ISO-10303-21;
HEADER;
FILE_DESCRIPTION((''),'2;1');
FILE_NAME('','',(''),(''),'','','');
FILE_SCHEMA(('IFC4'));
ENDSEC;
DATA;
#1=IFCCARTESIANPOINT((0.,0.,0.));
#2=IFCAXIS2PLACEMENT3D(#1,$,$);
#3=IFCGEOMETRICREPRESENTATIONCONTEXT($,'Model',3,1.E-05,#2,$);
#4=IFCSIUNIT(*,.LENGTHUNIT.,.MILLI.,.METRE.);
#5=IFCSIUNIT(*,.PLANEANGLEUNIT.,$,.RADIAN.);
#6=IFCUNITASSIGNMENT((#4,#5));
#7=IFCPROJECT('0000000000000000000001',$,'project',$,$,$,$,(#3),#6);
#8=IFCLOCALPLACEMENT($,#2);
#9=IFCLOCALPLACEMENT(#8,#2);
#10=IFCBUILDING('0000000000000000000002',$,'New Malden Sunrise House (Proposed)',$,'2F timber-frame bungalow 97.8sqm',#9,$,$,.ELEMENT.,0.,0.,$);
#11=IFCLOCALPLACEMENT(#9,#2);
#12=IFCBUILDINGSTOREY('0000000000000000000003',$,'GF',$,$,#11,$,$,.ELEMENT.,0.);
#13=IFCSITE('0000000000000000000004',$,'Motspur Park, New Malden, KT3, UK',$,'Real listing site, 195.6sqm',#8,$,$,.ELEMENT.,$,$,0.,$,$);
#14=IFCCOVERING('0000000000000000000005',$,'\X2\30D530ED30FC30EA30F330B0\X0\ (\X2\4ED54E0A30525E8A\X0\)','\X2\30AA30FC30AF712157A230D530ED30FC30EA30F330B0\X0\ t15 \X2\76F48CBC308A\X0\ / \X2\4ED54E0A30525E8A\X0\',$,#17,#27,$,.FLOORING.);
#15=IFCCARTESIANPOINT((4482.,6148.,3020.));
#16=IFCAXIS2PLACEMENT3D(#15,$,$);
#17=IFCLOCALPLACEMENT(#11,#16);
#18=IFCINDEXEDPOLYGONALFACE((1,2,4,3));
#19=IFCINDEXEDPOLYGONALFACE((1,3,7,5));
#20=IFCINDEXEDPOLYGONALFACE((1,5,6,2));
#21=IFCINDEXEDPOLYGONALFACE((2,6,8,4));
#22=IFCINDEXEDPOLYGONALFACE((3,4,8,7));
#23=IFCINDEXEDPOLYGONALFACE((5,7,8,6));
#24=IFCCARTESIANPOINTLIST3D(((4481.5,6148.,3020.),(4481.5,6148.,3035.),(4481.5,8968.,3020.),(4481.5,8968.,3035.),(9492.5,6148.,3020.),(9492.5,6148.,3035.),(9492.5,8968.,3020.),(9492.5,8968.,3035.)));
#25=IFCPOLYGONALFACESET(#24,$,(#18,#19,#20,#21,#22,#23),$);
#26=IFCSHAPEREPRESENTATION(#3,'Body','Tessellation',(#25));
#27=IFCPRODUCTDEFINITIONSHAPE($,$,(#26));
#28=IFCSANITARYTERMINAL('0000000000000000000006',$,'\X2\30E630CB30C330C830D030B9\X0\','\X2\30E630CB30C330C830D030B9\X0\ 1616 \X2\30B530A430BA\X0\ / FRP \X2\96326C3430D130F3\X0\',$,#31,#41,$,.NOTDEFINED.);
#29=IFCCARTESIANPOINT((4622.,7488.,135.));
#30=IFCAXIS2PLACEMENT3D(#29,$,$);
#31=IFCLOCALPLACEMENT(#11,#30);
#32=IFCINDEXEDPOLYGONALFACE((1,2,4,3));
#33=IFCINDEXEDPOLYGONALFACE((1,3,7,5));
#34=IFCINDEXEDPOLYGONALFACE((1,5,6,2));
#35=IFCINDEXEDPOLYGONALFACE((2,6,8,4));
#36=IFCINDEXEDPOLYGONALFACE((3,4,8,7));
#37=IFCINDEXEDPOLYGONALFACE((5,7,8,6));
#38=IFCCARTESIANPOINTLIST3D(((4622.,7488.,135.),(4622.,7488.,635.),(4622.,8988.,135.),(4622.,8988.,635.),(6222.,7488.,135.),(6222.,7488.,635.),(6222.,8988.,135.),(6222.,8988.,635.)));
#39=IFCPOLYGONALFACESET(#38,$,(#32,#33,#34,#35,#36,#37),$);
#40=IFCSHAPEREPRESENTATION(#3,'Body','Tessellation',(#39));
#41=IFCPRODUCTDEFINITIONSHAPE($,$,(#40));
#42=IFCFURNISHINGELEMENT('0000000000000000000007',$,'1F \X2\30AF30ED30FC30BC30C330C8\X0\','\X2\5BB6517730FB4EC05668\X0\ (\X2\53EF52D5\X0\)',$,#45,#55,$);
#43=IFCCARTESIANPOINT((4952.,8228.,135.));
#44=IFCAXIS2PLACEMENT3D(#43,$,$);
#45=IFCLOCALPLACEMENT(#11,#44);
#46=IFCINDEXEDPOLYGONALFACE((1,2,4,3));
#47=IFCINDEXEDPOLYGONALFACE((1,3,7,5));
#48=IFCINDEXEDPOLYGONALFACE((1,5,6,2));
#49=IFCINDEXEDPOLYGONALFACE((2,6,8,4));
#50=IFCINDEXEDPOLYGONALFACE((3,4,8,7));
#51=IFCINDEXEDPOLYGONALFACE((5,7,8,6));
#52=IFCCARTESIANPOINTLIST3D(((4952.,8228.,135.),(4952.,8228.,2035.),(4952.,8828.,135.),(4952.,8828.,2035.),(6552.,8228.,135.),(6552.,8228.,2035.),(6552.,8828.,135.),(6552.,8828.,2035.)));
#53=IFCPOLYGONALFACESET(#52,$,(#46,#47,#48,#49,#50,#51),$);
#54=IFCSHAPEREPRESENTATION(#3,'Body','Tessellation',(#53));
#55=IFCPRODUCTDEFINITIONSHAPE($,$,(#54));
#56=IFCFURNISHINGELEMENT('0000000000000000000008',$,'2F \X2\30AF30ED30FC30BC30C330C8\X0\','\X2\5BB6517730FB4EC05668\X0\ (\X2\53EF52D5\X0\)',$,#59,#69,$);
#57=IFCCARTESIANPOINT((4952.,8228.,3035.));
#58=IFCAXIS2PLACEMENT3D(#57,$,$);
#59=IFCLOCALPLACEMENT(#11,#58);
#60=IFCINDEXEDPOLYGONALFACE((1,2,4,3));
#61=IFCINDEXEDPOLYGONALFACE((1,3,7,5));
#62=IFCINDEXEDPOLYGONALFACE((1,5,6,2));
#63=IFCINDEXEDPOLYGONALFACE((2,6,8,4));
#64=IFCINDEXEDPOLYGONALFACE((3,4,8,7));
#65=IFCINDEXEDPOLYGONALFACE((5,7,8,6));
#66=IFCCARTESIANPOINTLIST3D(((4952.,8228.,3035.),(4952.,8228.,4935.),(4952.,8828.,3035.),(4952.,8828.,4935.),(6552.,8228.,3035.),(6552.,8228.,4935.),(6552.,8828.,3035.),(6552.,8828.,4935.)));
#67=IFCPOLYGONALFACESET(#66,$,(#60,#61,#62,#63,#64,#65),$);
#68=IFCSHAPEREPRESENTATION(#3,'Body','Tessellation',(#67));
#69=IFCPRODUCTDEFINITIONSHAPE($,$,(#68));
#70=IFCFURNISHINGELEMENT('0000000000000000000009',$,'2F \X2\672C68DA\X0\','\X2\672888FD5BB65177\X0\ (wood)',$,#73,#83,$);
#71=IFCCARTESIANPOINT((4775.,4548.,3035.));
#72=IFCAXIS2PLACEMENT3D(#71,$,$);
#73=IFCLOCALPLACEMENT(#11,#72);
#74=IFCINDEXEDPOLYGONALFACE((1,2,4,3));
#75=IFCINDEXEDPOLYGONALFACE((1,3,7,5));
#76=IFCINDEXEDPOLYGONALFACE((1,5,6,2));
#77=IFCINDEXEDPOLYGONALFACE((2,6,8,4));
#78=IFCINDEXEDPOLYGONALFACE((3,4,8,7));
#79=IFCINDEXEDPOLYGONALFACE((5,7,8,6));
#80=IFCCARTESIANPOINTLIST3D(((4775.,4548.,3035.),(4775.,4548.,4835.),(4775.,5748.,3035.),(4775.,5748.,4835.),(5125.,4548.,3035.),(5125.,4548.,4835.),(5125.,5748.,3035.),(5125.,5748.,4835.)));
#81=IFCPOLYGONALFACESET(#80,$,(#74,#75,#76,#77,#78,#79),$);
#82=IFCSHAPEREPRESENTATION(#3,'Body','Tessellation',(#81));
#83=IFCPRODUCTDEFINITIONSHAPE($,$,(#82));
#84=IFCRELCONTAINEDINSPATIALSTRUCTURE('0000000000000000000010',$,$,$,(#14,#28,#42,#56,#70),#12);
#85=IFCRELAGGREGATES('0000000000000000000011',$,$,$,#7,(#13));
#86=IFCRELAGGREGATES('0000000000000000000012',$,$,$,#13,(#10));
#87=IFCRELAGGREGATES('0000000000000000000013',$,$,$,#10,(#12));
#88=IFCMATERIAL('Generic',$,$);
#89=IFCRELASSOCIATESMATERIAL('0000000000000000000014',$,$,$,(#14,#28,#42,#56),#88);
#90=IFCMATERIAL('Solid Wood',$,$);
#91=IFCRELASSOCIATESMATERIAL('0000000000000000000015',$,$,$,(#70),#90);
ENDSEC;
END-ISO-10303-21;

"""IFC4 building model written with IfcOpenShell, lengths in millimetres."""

from ifc_helpers import new_model, si_unit, frame, frame_2d, origin, place, context, project, spatial, rectangle, extrude, material, element, save


model = new_model("IFC4")

# Units and contexts
model_context = context("Model", 3, precision=1e-05, world=origin())
ifc_project = project(units=[si_unit("LENGTHUNIT", "METRE", prefix="MILLI"), si_unit("PLANEANGLEUNIT", "RADIAN")], contexts=[model_context])

# Site, building, storey
site_placement = place(None, origin())
site = spatial("IfcSite", under=ifc_project, at=site_placement, Name="Motspur Park, New Malden, KT3, UK", ObjectType="Real listing site, 195.6sqm", CompositionType="ELEMENT", RefElevation=0.0)
building_placement = place(site_placement, origin())
building = spatial("IfcBuilding", under=site, at=building_placement, Name="New Malden Sunrise House (Proposed)", ObjectType="2F timber-frame bungalow 97.8sqm", CompositionType="ELEMENT", ElevationOfRefHeight=0.0, ElevationOfTerrain=0.0)
storey_placement = place(building_placement, origin())
storey = spatial("IfcBuildingStorey", under=building, at=storey_placement, Name="GF", CompositionType="ELEMENT", Elevation=0.0)

# Shared definitions
ifc_material_1 = material(Name="Solid Wood")

# Covering
ifc_material_2 = material(Name="Generic")
covering_1_placement = place(storey_placement, frame((4482.0, 6148.0, 3020.0)))
element("IfcCovering", 1, at=covering_1_placement, inside=storey, material=ifc_material_2, Name="フローリング (仕上げ床)", Description="オーク無垢フローリング t15 直貼り / 仕上げ床", PredefinedType="FLOORING", context=model_context, shape_type="SweptSolid", body=[
    extrude(rectangle(XDim=5011.0, YDim=2820.0, at=frame_2d((2505.0, 1410.0))), frame((4482.0, 6148.0, 3020.0)), (0.0, 0.0, 1.0), 15.0),
])

# Sanitary terminal
sanitary_terminal_placement = place(storey_placement, frame((4622.0, 7488.0, 135.0)))
element("IfcSanitaryTerminal", 2, at=sanitary_terminal_placement, inside=storey, material=ifc_material_2, Name="ユニットバス", Description="ユニットバス 1616 サイズ / FRP 防水パン", PredefinedType="NOTDEFINED", context=model_context, shape_type="SweptSolid", body=[
    extrude(rectangle(XDim=1600.0, YDim=1500.0, at=frame_2d((800.0, 750.0))), frame((4622.0, 7488.0, 135.0)), (0.0, 0.0, 1.0), 500.0),
])

# Furnishing elements
furnishing_1_placement = place(storey_placement, frame((4952.0, 8228.0, 135.0)))
element("IfcFurnishingElement", 3, at=furnishing_1_placement, inside=storey, material=ifc_material_2, Name="1F クローゼット", Description="家具・什器 (可動)", context=model_context, shape_type="SweptSolid", body=[
    extrude(rectangle(XDim=1600.0, YDim=600.0, at=frame_2d((800.0, 300.0))), frame((4952.0, 8228.0, 135.0)), (0.0, 0.0, 1.0), 1900.0),
])
furnishing_2_placement = place(storey_placement, frame((4952.0, 8228.0, 3035.0)))
element("IfcFurnishingElement", 4, at=furnishing_2_placement, inside=storey, material=ifc_material_2, Name="2F クローゼット", Description="家具・什器 (可動)", context=model_context, shape_type="SweptSolid", body=[
    extrude(rectangle(XDim=1600.0, YDim=600.0, at=frame_2d((800.0, 300.0))), frame((4952.0, 8228.0, 3035.0)), (0.0, 0.0, 1.0), 1900.0),
])
furnishing_3_placement = place(storey_placement, frame((4775.0, 4548.0, 3035.0)))
element("IfcFurnishingElement", 5, at=furnishing_3_placement, inside=storey, material=ifc_material_1, Name="2F 本棚", Description="木製家具 (wood)", context=model_context, shape_type="SweptSolid", body=[
    extrude(rectangle(XDim=350.0, YDim=1200.0, at=frame_2d((175.0, 600.0))), frame((4775.0, 4548.0, 3035.0)), (0.0, 0.0, 1.0), 1800.0),
])

save(model, "model.ifc")
